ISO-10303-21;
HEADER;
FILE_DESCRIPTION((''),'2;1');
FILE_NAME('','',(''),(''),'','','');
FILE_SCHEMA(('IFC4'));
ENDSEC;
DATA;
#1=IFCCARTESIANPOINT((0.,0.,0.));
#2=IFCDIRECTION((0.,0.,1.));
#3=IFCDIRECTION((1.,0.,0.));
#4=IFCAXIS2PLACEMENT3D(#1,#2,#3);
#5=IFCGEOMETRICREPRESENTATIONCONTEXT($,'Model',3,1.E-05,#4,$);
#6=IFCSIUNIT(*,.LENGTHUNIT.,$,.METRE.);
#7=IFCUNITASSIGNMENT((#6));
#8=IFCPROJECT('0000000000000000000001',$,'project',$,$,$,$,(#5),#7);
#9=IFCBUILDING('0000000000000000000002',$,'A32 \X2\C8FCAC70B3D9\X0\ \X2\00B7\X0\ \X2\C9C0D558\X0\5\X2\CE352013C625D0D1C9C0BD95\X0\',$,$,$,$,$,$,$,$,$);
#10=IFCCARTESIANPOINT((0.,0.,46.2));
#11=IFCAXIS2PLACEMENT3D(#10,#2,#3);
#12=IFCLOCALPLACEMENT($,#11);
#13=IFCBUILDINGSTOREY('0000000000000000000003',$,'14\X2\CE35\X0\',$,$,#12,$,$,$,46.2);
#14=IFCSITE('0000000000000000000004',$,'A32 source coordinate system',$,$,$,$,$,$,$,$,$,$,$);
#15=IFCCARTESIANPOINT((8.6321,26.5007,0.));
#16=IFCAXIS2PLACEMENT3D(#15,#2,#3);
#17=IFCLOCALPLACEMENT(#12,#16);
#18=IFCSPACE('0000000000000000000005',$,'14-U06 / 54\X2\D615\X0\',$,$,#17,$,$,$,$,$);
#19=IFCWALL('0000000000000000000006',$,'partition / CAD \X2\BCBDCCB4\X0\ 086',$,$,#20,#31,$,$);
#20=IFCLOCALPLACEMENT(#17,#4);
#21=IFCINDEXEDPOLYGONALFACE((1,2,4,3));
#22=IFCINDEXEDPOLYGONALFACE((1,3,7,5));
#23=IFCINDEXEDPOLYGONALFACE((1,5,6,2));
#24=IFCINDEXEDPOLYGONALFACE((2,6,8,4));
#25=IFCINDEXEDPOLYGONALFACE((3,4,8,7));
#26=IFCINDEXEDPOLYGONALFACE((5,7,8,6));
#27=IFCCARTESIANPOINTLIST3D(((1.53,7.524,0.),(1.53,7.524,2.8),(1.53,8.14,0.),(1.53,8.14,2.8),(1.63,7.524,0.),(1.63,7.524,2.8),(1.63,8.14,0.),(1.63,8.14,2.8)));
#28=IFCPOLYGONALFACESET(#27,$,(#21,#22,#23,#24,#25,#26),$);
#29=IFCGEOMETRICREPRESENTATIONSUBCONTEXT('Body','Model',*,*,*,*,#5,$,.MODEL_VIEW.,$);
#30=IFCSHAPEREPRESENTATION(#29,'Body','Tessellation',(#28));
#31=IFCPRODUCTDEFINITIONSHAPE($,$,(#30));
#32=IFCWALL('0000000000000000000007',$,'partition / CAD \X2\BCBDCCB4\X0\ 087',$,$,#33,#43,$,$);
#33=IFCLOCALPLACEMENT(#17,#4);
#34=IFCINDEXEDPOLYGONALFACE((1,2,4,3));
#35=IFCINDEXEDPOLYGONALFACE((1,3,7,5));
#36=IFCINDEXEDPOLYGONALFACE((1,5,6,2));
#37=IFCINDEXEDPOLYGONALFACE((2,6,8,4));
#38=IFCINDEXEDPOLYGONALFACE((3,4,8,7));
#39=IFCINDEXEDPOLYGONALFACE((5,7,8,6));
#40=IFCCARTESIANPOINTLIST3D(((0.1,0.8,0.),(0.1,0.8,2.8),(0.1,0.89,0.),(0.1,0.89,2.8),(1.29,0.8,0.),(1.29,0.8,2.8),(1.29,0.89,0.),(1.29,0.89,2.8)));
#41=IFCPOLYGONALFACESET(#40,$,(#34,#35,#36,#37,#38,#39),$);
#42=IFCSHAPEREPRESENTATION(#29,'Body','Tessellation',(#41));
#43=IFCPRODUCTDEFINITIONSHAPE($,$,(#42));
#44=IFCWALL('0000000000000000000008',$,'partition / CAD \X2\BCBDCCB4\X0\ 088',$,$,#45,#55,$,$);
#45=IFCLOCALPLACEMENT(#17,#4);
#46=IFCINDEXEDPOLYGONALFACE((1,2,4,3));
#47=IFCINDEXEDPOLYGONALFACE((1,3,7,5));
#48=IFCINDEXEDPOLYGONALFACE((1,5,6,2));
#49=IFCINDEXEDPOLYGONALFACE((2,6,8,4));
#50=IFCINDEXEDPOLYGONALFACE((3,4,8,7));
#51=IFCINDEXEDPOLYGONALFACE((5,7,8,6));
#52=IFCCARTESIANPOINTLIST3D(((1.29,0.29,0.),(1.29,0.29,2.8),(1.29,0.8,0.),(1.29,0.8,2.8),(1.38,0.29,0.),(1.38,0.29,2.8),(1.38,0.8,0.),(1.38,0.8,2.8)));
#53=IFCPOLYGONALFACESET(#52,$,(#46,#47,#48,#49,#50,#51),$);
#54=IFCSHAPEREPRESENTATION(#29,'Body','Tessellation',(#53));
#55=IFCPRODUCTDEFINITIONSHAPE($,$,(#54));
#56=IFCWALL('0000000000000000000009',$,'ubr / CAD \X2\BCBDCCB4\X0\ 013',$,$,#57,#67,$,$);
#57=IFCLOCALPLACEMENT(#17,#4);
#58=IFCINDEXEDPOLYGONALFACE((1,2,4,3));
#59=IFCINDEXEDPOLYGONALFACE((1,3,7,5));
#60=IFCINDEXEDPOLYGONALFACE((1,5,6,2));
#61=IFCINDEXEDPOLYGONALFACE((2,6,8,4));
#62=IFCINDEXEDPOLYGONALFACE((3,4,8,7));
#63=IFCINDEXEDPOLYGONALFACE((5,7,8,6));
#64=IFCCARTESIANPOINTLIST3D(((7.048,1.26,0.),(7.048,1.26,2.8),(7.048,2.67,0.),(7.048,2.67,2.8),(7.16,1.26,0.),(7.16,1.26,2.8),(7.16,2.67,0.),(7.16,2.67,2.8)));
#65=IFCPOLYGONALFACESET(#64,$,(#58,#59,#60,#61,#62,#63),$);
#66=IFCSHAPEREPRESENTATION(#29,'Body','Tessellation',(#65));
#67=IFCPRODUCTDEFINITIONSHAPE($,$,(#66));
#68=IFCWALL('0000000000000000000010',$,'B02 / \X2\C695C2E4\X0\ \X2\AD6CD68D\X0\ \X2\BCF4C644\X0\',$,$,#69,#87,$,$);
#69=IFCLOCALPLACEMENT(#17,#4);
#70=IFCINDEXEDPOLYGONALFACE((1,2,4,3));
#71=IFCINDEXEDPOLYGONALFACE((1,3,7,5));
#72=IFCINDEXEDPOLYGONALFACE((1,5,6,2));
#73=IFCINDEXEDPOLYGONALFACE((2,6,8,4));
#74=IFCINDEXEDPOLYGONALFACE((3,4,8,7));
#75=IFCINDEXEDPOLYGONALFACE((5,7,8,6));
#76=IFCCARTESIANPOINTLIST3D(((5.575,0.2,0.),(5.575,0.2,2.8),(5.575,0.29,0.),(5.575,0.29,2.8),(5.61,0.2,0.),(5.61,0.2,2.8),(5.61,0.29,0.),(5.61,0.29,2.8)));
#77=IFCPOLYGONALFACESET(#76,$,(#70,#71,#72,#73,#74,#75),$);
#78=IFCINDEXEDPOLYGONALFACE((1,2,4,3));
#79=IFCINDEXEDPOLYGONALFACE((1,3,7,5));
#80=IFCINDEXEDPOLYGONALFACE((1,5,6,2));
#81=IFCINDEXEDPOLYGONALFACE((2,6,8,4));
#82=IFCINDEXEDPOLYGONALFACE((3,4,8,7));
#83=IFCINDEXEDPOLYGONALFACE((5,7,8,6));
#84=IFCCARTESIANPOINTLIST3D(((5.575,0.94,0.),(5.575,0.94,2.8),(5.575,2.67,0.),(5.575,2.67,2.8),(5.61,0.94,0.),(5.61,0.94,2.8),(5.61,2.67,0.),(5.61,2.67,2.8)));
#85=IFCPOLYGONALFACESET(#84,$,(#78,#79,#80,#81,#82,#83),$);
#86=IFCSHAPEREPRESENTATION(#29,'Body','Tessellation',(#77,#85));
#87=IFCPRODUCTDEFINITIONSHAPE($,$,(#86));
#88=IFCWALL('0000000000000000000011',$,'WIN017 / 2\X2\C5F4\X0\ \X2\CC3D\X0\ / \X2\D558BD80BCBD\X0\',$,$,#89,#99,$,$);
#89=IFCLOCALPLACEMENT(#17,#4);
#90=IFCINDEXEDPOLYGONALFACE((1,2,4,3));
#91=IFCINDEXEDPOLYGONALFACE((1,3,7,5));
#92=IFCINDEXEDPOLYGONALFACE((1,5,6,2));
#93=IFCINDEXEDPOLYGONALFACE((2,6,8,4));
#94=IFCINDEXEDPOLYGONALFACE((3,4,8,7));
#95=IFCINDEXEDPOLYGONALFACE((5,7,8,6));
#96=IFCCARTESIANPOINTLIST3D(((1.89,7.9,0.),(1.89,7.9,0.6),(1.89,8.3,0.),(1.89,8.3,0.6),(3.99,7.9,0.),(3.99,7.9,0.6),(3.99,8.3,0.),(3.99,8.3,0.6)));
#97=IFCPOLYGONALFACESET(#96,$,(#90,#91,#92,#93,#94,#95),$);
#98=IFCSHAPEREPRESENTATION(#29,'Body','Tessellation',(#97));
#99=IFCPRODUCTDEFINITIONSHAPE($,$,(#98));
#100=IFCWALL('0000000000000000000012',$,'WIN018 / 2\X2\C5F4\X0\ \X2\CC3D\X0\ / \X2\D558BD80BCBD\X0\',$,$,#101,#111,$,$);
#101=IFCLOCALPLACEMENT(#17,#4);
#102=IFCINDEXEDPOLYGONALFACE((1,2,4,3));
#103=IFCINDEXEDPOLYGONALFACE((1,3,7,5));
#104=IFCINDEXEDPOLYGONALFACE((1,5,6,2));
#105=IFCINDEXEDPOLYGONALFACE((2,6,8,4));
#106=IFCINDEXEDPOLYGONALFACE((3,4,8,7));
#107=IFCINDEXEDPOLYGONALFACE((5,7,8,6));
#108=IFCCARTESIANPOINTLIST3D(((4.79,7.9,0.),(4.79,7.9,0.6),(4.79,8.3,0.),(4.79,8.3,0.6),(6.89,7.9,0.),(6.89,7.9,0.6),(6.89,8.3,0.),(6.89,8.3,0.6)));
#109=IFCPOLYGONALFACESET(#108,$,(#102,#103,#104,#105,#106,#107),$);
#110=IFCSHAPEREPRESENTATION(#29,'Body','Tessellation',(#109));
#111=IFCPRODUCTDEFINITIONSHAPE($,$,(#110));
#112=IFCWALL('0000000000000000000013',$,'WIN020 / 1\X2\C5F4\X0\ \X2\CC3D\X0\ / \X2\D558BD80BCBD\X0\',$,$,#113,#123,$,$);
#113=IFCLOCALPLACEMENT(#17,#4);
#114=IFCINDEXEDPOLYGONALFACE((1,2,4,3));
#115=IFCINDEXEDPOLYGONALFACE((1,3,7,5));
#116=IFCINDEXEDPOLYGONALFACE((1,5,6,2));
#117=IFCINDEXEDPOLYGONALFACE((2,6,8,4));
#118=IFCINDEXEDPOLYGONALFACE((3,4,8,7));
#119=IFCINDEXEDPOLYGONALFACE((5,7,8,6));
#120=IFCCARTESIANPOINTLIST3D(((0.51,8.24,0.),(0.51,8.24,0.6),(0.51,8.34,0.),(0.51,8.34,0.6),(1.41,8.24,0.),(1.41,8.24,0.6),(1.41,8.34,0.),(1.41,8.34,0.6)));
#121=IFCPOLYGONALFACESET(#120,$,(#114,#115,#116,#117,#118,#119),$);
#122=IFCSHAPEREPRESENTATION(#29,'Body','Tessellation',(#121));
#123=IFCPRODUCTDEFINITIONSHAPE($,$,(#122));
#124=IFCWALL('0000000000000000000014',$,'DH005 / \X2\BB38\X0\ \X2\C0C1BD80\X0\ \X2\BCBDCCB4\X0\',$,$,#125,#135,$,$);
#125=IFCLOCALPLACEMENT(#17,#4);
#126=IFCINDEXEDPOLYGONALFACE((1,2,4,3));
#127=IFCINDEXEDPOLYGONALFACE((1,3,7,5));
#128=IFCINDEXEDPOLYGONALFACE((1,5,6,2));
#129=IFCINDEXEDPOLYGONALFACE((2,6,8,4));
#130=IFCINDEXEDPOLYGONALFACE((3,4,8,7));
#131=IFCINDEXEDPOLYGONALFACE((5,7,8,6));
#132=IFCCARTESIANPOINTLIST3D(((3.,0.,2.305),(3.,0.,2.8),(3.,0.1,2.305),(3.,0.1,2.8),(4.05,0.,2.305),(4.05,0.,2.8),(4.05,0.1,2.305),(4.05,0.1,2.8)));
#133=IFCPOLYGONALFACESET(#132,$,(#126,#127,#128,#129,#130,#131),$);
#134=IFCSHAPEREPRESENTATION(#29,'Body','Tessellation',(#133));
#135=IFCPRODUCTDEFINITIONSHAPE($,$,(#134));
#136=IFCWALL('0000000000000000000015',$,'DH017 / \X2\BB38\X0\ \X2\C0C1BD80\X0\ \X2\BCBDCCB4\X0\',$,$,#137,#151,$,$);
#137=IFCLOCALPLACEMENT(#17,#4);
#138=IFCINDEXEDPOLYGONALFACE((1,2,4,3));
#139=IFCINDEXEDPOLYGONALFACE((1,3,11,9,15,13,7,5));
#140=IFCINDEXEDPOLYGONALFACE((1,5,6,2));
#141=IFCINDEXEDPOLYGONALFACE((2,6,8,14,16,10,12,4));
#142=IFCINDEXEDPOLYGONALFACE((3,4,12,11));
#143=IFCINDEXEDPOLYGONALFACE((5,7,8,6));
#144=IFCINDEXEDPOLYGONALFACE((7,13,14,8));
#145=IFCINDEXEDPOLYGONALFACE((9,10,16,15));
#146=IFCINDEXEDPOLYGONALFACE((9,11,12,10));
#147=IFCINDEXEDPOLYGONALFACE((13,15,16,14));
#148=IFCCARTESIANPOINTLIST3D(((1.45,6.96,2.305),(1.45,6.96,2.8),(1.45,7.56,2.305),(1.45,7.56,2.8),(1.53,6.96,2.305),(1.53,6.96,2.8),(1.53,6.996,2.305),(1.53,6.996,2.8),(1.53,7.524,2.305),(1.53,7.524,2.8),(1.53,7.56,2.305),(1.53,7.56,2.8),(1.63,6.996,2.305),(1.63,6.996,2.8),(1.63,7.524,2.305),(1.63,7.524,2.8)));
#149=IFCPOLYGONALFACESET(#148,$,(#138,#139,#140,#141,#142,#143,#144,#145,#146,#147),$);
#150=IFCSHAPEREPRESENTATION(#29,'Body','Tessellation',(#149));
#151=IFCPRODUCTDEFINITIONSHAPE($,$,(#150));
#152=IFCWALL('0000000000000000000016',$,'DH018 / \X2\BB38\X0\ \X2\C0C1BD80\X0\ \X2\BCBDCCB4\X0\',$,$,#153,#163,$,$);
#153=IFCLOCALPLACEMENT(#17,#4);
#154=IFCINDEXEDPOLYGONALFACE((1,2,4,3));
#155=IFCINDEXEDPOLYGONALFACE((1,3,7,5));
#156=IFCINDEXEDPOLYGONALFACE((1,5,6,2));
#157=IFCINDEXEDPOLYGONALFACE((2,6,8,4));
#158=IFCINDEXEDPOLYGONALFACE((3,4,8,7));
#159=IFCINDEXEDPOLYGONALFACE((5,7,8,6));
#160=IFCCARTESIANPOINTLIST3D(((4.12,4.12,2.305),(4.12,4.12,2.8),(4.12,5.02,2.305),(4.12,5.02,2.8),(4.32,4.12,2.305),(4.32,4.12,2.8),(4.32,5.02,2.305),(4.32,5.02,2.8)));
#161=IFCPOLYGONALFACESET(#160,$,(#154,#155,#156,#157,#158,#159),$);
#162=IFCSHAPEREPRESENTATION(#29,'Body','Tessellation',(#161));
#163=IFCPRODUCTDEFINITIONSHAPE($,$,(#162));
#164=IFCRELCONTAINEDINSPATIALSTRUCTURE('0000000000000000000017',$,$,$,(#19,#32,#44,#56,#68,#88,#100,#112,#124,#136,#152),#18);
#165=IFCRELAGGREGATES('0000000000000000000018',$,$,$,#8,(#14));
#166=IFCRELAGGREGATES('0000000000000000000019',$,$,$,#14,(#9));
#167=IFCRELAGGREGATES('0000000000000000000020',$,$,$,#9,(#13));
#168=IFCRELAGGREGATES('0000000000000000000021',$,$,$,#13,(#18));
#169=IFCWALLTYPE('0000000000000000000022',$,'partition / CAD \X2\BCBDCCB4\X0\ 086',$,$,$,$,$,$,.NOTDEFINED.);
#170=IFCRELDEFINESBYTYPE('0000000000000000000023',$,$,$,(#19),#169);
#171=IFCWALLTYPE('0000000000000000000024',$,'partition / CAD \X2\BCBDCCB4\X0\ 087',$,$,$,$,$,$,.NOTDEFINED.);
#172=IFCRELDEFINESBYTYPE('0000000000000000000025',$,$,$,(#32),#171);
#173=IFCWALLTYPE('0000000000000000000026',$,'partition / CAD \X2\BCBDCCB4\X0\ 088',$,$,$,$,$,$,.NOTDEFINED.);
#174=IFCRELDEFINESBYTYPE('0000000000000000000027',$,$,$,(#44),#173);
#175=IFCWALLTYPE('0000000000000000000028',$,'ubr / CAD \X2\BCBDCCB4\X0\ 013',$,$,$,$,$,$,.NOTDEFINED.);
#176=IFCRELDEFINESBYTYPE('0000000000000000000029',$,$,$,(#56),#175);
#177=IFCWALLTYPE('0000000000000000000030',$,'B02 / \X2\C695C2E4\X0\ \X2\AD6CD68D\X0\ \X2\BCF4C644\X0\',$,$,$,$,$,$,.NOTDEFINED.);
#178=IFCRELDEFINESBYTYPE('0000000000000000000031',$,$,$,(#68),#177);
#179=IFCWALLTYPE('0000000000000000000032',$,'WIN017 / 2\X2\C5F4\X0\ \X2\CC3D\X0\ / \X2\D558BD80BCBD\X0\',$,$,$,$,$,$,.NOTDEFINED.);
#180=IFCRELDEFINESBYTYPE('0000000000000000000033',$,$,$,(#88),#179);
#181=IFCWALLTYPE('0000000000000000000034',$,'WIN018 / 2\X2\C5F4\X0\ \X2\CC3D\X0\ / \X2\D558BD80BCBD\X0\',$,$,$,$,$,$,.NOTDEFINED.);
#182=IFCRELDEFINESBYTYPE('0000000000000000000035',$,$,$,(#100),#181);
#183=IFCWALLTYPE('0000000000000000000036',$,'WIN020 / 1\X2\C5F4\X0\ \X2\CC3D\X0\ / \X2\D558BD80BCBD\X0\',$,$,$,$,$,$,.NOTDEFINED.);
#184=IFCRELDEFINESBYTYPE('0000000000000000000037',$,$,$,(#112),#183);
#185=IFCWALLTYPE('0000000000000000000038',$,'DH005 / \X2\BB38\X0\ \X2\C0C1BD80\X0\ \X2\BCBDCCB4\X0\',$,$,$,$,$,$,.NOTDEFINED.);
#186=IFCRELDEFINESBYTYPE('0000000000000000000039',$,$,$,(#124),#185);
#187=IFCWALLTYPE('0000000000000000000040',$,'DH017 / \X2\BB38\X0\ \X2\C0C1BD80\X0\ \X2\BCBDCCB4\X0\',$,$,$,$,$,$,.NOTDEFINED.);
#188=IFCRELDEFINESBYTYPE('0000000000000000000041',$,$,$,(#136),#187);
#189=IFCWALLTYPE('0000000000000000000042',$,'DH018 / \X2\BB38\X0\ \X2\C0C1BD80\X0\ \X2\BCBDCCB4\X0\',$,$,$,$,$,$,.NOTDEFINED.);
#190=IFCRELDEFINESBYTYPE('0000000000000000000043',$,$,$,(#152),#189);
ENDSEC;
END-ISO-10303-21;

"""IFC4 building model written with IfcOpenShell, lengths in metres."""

from ifc_helpers import new_model, si_unit, frame, origin, origin_with_axes, place, context, subcontext, project, spatial, polyline, outline, extrude, source, transform, mapped, type_object, type_shapes, element, save


model = new_model("IFC4")

# Units and contexts
model_context = context("Model", 3, precision=1e-05, world=origin_with_axes())
body_context = subcontext(model_context, "Body", "Model", "MODEL_VIEW")
ifc_project = project(units=[si_unit("LENGTHUNIT", "METRE")], contexts=[model_context])

# Site, building, storey, space
site = spatial("IfcSite", under=ifc_project, Name="A32 source coordinate system")
building = spatial("IfcBuilding", under=site, Name="A32 주거동 · 지하5층–옥탑지붕")
storey_placement = place(None, frame((0.0, 0.0, 46.2), z_axis=(0.0, 0.0, 1.0), x_axis=(1.0, 0.0, 0.0)))
storey = spatial("IfcBuildingStorey", under=building, at=storey_placement, Name="14층", Elevation=46.2)
space_placement = place(storey_placement, frame((8.6321, 26.5007, 0.0), z_axis=(0.0, 0.0, 1.0), x_axis=(1.0, 0.0, 0.0)))
space = spatial("IfcSpace", under=storey, at=space_placement, Name="14-U06 / 54형")

# Walls
wall_type_1 = type_object("IfcWallType", Name="partition / CAD 벽체 086", PredefinedType="NOTDEFINED")
shared_shape_1 = source(origin(), body_context, "Body", "SweptSolid", [
    extrude(outline(polyline([(1.53, 7.524), (1.53, 8.14), (1.63, 8.14), (1.63, 7.524), (1.53, 7.524)])), origin(), (0.0, 0.0, 1.0), 2.8),
])
type_shapes(wall_type_1, [shared_shape_1])
wall_1_placement = place(space_placement, origin_with_axes())
element("IfcWall", 1, at=wall_1_placement, inside=space, type_object=wall_type_1, Name="partition / CAD 벽체 086", context=body_context, shape_type="MappedRepresentation", body=[
    mapped(shared_shape_1, transform((0.0, 0.0, 0.0), scale=1.0)),
])
wall_type_2 = type_object("IfcWallType", Name="partition / CAD 벽체 087", PredefinedType="NOTDEFINED")
shared_shape_2 = source(origin(), body_context, "Body", "SweptSolid", [
    extrude(outline(polyline([(1.29, 0.8), (0.1, 0.8), (0.1, 0.89), (1.29, 0.89), (1.29, 0.8)])), origin(), (0.0, 0.0, 1.0), 2.8),
])
type_shapes(wall_type_2, [shared_shape_2])
wall_2_placement = place(space_placement, origin_with_axes())
element("IfcWall", 2, at=wall_2_placement, inside=space, type_object=wall_type_2, Name="partition / CAD 벽체 087", context=body_context, shape_type="MappedRepresentation", body=[
    mapped(shared_shape_2, transform((0.0, 0.0, 0.0), scale=1.0)),
])
wall_type_3 = type_object("IfcWallType", Name="partition / CAD 벽체 088", PredefinedType="NOTDEFINED")
shared_shape_3 = source(origin(), body_context, "Body", "SweptSolid", [
    extrude(outline(polyline([(1.29, 0.29), (1.29, 0.8), (1.38, 0.8), (1.38, 0.29), (1.29, 0.29)])), origin(), (0.0, 0.0, 1.0), 2.8),
])
type_shapes(wall_type_3, [shared_shape_3])
wall_3_placement = place(space_placement, origin_with_axes())
element("IfcWall", 3, at=wall_3_placement, inside=space, type_object=wall_type_3, Name="partition / CAD 벽체 088", context=body_context, shape_type="MappedRepresentation", body=[
    mapped(shared_shape_3, transform((0.0, 0.0, 0.0), scale=1.0)),
])
wall_type_4 = type_object("IfcWallType", Name="ubr / CAD 벽체 013", PredefinedType="NOTDEFINED")
shared_shape_4 = source(origin(), body_context, "Body", "SweptSolid", [
    extrude(outline(polyline([(7.16, 1.26), (7.048, 1.26), (7.048, 2.67), (7.16, 2.67), (7.16, 1.26)])), origin(), (0.0, 0.0, 1.0), 2.8),
])
type_shapes(wall_type_4, [shared_shape_4])
wall_4_placement = place(space_placement, origin_with_axes())
element("IfcWall", 4, at=wall_4_placement, inside=space, type_object=wall_type_4, Name="ubr / CAD 벽체 013", context=body_context, shape_type="MappedRepresentation", body=[
    mapped(shared_shape_4, transform((0.0, 0.0, 0.0), scale=1.0)),
])
wall_type_5 = type_object("IfcWallType", Name="B02 / 욕실 구획 보완", PredefinedType="NOTDEFINED")
shared_shape_5 = source(origin(), body_context, "Body", "SweptSolid", [
    extrude(outline(polyline([(5.575, 0.2), (5.575, 0.29), (5.61, 0.29), (5.61, 0.2), (5.575, 0.2)])), origin(), (0.0, 0.0, 1.0), 2.8),
    extrude(outline(polyline([(5.575, 0.94), (5.575, 2.67), (5.61, 2.67), (5.61, 0.94), (5.575, 0.94)])), origin(), (0.0, 0.0, 1.0), 2.8),
])
type_shapes(wall_type_5, [shared_shape_5])
wall_5_placement = place(space_placement, origin_with_axes())
element("IfcWall", 5, at=wall_5_placement, inside=space, type_object=wall_type_5, Name="B02 / 욕실 구획 보완", context=body_context, shape_type="MappedRepresentation", body=[
    mapped(shared_shape_5, transform((0.0, 0.0, 0.0), scale=1.0)),
])
wall_type_6 = type_object("IfcWallType", Name="WIN017 / 2열 창 / 하부벽", PredefinedType="NOTDEFINED")
shared_shape_6 = source(origin(), body_context, "Body", "SweptSolid", [
    extrude(outline(polyline([(3.99, 8.3), (3.99, 7.9), (1.89, 7.9), (1.89, 8.3), (3.99, 8.3)])), origin(), (0.0, 0.0, 1.0), 0.6),
])
type_shapes(wall_type_6, [shared_shape_6])
wall_6_placement = place(space_placement, origin_with_axes())
element("IfcWall", 6, at=wall_6_placement, inside=space, type_object=wall_type_6, Name="WIN017 / 2열 창 / 하부벽", context=body_context, shape_type="MappedRepresentation", body=[
    mapped(shared_shape_6, transform((0.0, 0.0, 0.0), scale=1.0)),
])
wall_type_7 = type_object("IfcWallType", Name="WIN018 / 2열 창 / 하부벽", PredefinedType="NOTDEFINED")
shared_shape_7 = source(origin(), body_context, "Body", "SweptSolid", [
    extrude(outline(polyline([(6.89, 8.3), (6.89, 7.9), (4.79, 7.9), (4.79, 8.3), (6.89, 8.3)])), origin(), (0.0, 0.0, 1.0), 0.6),
])
type_shapes(wall_type_7, [shared_shape_7])
wall_7_placement = place(space_placement, origin_with_axes())
element("IfcWall", 7, at=wall_7_placement, inside=space, type_object=wall_type_7, Name="WIN018 / 2열 창 / 하부벽", context=body_context, shape_type="MappedRepresentation", body=[
    mapped(shared_shape_7, transform((0.0, 0.0, 0.0), scale=1.0)),
])
wall_type_8 = type_object("IfcWallType", Name="WIN020 / 1열 창 / 하부벽", PredefinedType="NOTDEFINED")
shared_shape_8 = source(origin(), body_context, "Body", "SweptSolid", [
    extrude(outline(polyline([(1.41, 8.34), (1.41, 8.24), (0.51, 8.24), (0.51, 8.34), (1.41, 8.34)])), origin(), (0.0, 0.0, 1.0), 0.6),
])
type_shapes(wall_type_8, [shared_shape_8])
wall_8_placement = place(space_placement, origin_with_axes())
element("IfcWall", 8, at=wall_8_placement, inside=space, type_object=wall_type_8, Name="WIN020 / 1열 창 / 하부벽", context=body_context, shape_type="MappedRepresentation", body=[
    mapped(shared_shape_8, transform((0.0, 0.0, 0.0), scale=1.0)),
])
wall_type_9 = type_object("IfcWallType", Name="DH005 / 문 상부 벽체", PredefinedType="NOTDEFINED")
shared_shape_9 = source(origin(), body_context, "Body", "SweptSolid", [
    extrude(outline(polyline([(4.05, 0.0), (3.0, 0.0), (3.0, 0.1), (4.05, 0.1), (4.05, 0.0)])), frame((0.0, 0.0, 2.305)), (0.0, 0.0, 1.0), 0.495),
])
type_shapes(wall_type_9, [shared_shape_9])
wall_9_placement = place(space_placement, origin_with_axes())
element("IfcWall", 9, at=wall_9_placement, inside=space, type_object=wall_type_9, Name="DH005 / 문 상부 벽체", context=body_context, shape_type="MappedRepresentation", body=[
    mapped(shared_shape_9, transform((0.0, 0.0, 0.0), scale=1.0)),
])
wall_type_10 = type_object("IfcWallType", Name="DH017 / 문 상부 벽체", PredefinedType="NOTDEFINED")
shared_shape_10 = source(origin(), body_context, "Body", "SweptSolid", [
    extrude(outline(polyline([(1.63, 7.524), (1.63, 6.996), (1.53, 6.996), (1.53, 6.96), (1.45, 6.96), (1.45, 7.56), (1.53, 7.56), (1.53, 7.524), (1.63, 7.524)])), frame((0.0, 0.0, 2.305)), (0.0, 0.0, 1.0), 0.495),
])
type_shapes(wall_type_10, [shared_shape_10])
wall_10_placement = place(space_placement, origin_with_axes())
element("IfcWall", 10, at=wall_10_placement, inside=space, type_object=wall_type_10, Name="DH017 / 문 상부 벽체", context=body_context, shape_type="MappedRepresentation", body=[
    mapped(shared_shape_10, transform((0.0, 0.0, 0.0), scale=1.0)),
])
wall_type_11 = type_object("IfcWallType", Name="DH018 / 문 상부 벽체", PredefinedType="NOTDEFINED")
shared_shape_11 = source(origin(), body_context, "Body", "SweptSolid", [
    extrude(outline(polyline([(4.32, 4.12), (4.12, 4.12), (4.12, 5.02), (4.32, 5.02), (4.32, 4.12)])), frame((0.0, 0.0, 2.305)), (0.0, 0.0, 1.0), 0.495),
])
type_shapes(wall_type_11, [shared_shape_11])
wall_11_placement = place(space_placement, origin_with_axes())
element("IfcWall", 11, at=wall_11_placement, inside=space, type_object=wall_type_11, Name="DH018 / 문 상부 벽체", context=body_context, shape_type="MappedRepresentation", body=[
    mapped(shared_shape_11, transform((0.0, 0.0, 0.0), scale=1.0)),
])

save(model, "model.ifc")
